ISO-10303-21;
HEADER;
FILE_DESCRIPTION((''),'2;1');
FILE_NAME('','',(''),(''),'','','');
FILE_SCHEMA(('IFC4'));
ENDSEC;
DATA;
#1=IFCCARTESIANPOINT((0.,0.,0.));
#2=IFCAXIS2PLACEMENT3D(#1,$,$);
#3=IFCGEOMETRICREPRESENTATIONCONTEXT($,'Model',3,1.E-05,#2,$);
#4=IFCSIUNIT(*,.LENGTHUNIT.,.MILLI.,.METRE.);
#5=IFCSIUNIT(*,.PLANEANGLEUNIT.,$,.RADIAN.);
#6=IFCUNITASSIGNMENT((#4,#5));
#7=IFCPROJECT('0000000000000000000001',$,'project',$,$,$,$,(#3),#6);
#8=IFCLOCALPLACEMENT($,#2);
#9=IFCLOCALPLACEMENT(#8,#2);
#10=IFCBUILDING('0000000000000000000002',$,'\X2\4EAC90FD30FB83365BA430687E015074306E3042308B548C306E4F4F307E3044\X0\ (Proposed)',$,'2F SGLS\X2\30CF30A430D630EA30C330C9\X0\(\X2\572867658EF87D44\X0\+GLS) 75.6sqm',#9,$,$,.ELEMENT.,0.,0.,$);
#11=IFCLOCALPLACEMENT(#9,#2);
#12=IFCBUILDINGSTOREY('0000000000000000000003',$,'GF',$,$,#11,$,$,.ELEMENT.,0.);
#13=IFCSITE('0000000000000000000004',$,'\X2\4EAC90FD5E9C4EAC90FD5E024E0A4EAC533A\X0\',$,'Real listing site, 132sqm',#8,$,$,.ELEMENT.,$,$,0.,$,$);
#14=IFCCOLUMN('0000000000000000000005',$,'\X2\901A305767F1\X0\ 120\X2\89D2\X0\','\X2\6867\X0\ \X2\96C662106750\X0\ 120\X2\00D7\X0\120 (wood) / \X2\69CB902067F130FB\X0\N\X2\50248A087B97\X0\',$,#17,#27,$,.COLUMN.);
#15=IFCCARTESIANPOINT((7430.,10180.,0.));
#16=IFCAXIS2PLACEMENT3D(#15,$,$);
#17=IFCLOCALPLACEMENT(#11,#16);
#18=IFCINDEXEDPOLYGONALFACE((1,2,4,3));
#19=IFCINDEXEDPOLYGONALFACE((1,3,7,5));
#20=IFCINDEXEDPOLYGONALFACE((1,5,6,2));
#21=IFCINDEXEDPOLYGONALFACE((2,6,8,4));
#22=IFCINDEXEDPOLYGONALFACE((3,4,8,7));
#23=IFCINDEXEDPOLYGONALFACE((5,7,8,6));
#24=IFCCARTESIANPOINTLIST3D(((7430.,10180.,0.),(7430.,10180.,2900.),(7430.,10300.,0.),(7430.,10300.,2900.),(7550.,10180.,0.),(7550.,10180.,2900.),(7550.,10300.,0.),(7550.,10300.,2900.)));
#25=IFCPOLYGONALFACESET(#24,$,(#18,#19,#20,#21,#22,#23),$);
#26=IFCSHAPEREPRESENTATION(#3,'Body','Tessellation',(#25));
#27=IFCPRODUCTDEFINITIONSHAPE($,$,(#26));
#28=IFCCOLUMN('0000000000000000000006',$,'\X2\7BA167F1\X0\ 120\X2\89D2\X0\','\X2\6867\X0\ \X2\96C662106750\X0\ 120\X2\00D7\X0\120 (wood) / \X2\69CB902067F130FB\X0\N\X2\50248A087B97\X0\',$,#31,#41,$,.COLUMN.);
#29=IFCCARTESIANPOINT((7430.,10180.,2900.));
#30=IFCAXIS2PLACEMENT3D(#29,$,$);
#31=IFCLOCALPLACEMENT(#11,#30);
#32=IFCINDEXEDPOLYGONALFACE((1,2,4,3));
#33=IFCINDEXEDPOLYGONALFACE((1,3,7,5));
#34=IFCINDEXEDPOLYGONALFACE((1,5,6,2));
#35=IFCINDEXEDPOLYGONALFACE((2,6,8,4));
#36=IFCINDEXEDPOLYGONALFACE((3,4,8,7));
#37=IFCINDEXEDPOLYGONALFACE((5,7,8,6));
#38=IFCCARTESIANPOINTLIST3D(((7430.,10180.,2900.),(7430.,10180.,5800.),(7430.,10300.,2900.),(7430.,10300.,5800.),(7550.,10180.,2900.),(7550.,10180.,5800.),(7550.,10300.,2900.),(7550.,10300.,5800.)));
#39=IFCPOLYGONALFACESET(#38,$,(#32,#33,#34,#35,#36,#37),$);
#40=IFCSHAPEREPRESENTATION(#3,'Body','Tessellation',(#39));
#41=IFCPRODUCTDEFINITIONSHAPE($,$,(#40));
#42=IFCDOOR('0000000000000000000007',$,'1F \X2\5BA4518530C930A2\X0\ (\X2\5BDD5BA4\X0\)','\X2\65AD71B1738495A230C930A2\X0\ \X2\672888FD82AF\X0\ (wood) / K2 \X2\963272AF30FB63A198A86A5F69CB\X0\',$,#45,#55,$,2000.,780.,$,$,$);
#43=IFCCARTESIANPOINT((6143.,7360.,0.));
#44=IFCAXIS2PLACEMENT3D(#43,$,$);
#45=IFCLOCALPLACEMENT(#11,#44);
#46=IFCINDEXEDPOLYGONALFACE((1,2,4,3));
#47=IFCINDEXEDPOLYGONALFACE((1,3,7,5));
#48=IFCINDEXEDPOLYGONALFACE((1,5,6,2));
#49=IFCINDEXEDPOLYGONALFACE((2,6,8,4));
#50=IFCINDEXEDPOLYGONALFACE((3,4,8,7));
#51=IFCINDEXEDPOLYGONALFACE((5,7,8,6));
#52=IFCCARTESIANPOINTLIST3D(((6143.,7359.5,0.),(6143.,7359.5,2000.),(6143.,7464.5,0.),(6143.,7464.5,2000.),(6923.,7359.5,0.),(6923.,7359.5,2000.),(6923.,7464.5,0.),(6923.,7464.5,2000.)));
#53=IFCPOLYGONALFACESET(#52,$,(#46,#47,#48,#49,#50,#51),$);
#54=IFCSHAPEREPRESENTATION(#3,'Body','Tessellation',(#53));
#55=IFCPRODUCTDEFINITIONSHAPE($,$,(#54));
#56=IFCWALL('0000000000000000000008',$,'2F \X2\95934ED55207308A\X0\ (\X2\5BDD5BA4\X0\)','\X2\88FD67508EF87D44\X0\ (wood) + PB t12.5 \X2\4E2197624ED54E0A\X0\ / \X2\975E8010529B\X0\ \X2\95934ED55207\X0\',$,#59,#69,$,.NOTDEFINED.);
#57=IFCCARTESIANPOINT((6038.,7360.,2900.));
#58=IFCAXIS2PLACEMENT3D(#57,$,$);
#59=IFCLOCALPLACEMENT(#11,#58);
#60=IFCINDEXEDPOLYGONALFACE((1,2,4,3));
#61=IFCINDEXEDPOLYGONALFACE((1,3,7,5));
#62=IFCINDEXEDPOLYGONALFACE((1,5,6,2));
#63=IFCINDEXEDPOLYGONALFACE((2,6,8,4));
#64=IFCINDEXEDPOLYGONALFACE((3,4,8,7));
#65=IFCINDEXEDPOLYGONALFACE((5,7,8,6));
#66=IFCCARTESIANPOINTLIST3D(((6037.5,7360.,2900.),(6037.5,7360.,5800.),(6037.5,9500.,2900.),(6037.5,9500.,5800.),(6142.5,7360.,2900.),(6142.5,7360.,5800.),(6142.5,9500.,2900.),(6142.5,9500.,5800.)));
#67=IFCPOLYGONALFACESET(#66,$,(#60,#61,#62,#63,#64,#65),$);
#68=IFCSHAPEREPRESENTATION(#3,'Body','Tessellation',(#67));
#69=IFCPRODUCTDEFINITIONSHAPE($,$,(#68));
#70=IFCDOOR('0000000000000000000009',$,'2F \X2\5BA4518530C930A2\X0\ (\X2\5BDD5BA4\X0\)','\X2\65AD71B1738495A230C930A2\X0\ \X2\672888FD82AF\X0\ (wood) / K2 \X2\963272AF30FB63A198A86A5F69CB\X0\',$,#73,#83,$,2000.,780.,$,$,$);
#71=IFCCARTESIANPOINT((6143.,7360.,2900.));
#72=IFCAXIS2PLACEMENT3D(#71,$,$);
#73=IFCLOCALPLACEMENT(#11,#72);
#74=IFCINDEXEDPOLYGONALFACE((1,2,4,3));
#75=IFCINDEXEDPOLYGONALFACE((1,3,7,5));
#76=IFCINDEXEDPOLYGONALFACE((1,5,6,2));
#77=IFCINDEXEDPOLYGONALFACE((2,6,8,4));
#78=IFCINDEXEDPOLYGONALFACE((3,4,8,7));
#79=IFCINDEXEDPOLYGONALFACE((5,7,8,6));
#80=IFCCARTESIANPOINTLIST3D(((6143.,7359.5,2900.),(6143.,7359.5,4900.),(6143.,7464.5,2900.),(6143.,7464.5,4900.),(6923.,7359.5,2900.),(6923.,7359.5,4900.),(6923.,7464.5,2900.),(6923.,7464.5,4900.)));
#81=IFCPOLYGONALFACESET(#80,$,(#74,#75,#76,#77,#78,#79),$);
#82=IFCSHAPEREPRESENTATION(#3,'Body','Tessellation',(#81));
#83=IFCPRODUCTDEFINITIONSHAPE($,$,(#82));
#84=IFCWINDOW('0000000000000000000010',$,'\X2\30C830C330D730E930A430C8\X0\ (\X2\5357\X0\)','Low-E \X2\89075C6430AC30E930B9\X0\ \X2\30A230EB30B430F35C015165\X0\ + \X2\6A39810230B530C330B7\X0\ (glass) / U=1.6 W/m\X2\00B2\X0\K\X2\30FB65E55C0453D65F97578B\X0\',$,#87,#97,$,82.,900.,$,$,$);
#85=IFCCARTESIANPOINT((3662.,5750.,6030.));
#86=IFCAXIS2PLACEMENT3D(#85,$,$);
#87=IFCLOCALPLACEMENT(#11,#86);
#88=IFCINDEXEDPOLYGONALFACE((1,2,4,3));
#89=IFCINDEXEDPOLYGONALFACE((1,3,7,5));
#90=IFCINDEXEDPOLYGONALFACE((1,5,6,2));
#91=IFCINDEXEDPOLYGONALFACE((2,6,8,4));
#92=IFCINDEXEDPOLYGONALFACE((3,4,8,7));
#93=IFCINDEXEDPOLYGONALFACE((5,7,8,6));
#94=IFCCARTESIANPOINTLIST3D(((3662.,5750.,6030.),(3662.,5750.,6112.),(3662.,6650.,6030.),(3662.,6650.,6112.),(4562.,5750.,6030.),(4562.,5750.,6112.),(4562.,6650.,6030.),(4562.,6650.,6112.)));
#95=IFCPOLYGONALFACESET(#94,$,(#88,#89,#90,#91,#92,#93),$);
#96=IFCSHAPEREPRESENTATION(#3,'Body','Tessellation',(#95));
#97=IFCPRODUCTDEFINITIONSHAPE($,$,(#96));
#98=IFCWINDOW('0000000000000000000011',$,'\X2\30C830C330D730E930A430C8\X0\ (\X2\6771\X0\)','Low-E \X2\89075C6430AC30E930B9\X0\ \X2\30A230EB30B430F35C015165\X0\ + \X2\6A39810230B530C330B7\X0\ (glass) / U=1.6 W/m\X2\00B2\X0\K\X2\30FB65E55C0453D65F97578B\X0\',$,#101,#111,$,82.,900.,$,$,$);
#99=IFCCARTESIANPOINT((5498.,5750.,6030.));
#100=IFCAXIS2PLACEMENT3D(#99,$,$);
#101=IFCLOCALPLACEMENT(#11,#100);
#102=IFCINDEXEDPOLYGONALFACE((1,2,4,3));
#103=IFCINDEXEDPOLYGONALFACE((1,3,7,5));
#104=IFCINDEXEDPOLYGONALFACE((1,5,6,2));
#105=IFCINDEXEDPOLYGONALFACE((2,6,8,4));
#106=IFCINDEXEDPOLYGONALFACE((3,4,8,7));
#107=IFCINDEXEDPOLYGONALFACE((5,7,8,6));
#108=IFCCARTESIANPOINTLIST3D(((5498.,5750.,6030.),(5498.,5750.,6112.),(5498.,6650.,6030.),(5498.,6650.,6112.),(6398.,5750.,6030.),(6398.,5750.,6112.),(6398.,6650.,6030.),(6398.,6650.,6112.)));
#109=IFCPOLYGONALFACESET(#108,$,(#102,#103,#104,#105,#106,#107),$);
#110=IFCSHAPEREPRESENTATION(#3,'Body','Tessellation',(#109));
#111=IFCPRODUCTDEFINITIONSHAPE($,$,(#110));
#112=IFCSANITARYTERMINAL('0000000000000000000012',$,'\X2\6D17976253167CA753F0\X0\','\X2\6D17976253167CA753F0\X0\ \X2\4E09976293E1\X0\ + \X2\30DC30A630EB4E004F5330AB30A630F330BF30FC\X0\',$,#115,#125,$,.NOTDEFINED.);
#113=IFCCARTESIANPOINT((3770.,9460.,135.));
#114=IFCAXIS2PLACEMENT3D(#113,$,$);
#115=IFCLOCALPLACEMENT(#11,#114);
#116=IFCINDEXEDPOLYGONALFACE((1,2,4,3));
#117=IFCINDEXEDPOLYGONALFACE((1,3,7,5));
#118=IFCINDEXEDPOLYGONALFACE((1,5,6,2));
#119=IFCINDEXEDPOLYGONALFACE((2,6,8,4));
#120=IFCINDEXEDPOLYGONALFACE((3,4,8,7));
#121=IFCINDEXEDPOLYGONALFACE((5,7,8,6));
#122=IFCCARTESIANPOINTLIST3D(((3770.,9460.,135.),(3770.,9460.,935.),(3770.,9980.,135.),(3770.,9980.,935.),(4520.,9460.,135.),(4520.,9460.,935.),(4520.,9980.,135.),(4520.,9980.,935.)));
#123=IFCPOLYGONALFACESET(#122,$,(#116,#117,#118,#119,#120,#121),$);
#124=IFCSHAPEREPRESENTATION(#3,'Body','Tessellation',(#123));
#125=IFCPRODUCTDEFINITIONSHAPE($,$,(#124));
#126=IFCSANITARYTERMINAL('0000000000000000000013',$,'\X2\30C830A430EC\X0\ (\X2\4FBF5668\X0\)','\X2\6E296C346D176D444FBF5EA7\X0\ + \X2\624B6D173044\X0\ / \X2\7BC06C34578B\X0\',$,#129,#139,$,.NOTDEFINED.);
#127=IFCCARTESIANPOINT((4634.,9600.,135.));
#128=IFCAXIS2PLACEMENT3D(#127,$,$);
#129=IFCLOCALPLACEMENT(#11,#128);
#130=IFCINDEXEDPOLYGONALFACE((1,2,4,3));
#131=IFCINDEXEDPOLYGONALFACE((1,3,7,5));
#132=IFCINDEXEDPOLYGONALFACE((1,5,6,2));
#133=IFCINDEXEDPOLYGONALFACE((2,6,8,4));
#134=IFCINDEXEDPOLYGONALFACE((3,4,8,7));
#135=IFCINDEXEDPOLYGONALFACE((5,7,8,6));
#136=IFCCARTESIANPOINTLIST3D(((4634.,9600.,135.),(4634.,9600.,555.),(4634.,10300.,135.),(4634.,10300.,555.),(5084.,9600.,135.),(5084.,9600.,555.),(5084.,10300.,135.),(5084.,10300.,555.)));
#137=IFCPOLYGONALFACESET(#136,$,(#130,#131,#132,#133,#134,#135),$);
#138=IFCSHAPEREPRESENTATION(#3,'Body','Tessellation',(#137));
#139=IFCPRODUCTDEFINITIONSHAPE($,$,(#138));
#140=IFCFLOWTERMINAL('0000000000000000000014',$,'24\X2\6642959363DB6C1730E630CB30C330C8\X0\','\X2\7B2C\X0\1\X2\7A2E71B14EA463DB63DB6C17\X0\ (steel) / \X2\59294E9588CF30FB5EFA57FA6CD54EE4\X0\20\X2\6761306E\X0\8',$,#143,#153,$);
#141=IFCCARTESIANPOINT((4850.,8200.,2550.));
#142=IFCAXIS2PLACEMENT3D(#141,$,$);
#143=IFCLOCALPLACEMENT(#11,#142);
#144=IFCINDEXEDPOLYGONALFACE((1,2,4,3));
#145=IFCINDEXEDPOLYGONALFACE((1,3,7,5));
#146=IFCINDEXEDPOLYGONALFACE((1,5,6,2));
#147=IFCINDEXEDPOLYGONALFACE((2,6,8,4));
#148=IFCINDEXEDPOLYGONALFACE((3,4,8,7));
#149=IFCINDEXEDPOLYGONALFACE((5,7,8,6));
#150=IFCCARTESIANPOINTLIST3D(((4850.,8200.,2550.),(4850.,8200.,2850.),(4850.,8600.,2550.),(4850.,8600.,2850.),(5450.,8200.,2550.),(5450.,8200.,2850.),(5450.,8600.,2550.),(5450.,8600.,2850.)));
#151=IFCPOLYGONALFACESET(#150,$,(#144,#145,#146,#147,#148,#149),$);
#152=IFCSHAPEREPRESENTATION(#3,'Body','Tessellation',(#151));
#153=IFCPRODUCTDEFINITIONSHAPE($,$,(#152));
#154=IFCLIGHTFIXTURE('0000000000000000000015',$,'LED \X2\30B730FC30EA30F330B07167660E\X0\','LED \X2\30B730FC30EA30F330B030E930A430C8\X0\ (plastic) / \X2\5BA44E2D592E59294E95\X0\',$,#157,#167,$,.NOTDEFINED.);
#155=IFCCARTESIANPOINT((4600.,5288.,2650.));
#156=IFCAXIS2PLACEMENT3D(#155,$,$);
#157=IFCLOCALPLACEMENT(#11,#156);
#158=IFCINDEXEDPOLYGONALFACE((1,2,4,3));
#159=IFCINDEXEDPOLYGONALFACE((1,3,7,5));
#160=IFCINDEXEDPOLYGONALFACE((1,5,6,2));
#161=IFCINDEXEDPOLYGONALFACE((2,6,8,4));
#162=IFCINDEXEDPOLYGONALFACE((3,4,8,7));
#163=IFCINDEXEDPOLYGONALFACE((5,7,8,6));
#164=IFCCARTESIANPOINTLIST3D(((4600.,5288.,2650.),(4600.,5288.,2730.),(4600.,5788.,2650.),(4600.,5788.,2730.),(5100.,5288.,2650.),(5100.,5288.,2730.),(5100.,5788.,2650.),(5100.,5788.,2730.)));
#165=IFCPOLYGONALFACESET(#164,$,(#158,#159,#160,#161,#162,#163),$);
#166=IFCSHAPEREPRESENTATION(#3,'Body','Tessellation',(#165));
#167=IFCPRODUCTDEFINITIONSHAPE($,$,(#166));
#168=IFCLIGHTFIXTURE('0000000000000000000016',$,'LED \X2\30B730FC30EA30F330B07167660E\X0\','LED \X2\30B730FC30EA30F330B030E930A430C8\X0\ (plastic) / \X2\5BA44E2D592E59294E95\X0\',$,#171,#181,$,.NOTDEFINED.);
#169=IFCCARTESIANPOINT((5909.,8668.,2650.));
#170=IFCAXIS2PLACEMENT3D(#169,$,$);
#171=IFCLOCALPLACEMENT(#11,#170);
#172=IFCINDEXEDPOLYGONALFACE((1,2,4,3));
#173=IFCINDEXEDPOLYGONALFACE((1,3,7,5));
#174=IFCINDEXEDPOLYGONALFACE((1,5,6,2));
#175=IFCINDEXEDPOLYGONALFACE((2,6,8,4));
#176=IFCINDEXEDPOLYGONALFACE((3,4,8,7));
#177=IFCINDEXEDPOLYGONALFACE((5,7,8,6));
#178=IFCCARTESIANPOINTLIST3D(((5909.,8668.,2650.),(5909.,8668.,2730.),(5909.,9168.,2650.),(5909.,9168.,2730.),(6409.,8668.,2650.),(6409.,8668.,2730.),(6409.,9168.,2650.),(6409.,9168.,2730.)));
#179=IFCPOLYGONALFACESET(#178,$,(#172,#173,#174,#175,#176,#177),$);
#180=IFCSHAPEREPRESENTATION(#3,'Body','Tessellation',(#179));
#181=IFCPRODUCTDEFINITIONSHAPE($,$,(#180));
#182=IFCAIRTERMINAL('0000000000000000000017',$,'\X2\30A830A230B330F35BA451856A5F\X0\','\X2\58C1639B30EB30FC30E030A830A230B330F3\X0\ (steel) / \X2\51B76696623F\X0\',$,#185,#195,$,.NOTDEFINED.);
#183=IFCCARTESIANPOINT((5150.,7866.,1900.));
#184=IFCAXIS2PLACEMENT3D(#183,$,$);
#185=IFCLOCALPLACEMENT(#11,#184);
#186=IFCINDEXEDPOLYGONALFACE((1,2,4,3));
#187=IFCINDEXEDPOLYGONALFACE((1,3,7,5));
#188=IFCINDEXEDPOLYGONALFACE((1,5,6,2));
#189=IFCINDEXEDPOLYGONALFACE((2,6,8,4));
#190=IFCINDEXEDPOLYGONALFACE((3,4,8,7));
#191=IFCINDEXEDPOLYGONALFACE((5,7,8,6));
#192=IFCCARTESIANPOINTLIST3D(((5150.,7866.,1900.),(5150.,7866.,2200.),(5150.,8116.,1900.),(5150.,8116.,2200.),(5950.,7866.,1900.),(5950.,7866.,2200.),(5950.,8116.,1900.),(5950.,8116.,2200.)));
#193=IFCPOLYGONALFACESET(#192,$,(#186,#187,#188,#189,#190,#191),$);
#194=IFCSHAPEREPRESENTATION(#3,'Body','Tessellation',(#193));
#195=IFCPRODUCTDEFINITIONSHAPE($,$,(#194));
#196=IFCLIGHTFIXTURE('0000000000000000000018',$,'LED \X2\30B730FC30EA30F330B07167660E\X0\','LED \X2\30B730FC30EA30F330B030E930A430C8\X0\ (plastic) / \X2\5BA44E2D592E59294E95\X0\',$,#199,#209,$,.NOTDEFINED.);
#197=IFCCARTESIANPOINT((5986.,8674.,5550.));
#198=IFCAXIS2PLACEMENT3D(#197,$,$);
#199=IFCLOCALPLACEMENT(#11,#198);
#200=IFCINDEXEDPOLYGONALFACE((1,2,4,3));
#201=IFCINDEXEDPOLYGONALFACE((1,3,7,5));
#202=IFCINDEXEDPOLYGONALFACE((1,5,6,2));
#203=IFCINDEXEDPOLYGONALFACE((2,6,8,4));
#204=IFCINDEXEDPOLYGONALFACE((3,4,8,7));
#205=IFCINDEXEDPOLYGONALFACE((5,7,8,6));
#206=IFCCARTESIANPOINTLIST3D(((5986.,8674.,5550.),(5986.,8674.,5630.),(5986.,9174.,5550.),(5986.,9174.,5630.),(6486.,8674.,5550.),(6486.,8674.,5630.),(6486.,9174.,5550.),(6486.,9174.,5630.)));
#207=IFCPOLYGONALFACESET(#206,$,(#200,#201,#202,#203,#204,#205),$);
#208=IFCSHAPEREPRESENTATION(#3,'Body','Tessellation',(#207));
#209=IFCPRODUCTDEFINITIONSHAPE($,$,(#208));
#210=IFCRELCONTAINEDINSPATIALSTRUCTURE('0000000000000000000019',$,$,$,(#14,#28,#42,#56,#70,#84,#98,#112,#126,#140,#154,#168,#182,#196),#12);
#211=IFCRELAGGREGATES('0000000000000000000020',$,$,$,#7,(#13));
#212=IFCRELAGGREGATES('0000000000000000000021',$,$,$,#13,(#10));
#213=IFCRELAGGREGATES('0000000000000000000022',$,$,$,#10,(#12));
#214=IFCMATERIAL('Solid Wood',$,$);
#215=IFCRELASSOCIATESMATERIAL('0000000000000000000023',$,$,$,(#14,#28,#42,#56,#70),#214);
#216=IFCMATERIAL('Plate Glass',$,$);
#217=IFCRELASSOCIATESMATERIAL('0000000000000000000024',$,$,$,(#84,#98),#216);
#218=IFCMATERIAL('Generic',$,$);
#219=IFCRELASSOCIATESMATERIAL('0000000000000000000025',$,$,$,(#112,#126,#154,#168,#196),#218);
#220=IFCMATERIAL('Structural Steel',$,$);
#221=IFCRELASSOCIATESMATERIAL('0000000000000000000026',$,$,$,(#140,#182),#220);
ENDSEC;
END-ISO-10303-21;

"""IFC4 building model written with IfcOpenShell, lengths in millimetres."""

from ifc_helpers import new_model, si_unit, frame, frame_2d, origin, place, context, project, spatial, rectangle, extrude, material, element, save


model = new_model("IFC4")

# Units and contexts
model_context = context("Model", 3, precision=1e-05, world=origin())
ifc_project = project(units=[si_unit("LENGTHUNIT", "METRE", prefix="MILLI"), si_unit("PLANEANGLEUNIT", "RADIAN")], contexts=[model_context])

# Site, building, storey
site_placement = place(None, origin())
site = spatial("IfcSite", under=ifc_project, at=site_placement, Name="京都府京都市上京区", ObjectType="Real listing site, 132sqm", CompositionType="ELEMENT", RefElevation=0.0)
building_placement = place(site_placement, origin())
building = spatial("IfcBuilding", under=site, at=building_placement, Name="京都・茶室と縁側のある和の住まい (Proposed)", ObjectType="2F SGLSハイブリッド(在来軸組+GLS) 75.6sqm", CompositionType="ELEMENT", ElevationOfRefHeight=0.0, ElevationOfTerrain=0.0)
storey_placement = place(building_placement, origin())
storey = spatial("IfcBuildingStorey", under=building, at=storey_placement, Name="GF", CompositionType="ELEMENT", Elevation=0.0)

# Columns
ifc_material_1 = material(Name="Solid Wood")
column_1_placement = place(storey_placement, frame((7430.0, 10180.0, 0.0)))
element("IfcColumn", 1, at=column_1_placement, inside=storey, material=ifc_material_1, Name="通し柱 120角", Description="桧 集成材 120×120 (wood) / 構造柱・N値計算", PredefinedType="COLUMN", context=model_context, shape_type="SweptSolid", body=[
    extrude(rectangle(XDim=120.0, YDim=120.0, at=frame_2d((60.0, 60.0))), frame((7430.0, 10180.0, 0.0)), (0.0, 0.0, 1.0), 2900.0),
])
column_2_placement = place(storey_placement, frame((7430.0, 10180.0, 2900.0)))
element("IfcColumn", 2, at=column_2_placement, inside=storey, material=ifc_material_1, Name="管柱 120角", Description="桧 集成材 120×120 (wood) / 構造柱・N値計算", PredefinedType="COLUMN", context=model_context, shape_type="SweptSolid", body=[
    extrude(rectangle(XDim=120.0, YDim=120.0, at=frame_2d((60.0, 60.0))), frame((7430.0, 10180.0, 2900.0)), (0.0, 0.0, 1.0), 2900.0),
])

# Door
door_1_placement = place(storey_placement, frame((6143.0, 7360.0, 0.0)))
element("IfcDoor", 3, at=door_1_placement, inside=storey, material=ifc_material_1, Name="1F 室内ドア (寝室)", Description="断熱玄関ドア 木製芯 (wood) / K2 防犯・採風機構", OverallHeight=2000.0, OverallWidth=780.0, context=model_context, shape_type="SweptSolid", body=[
    extrude(rectangle(XDim=780.0, YDim=105.0, at=frame_2d((390.0, 52.0))), frame((6143.0, 7360.0, 0.0)), (0.0, 0.0, 1.0), 2000.0),
])

# Wall
wall_1_placement = place(storey_placement, frame((6038.0, 7360.0, 2900.0)))
element("IfcWall", 4, at=wall_1_placement, inside=storey, material=ifc_material_1, Name="2F 間仕切り (寝室)", Description="製材軸組 (wood) + PB t12.5 両面仕上 / 非耐力 間仕切", PredefinedType="NOTDEFINED", context=model_context, shape_type="SweptSolid", body=[
    extrude(rectangle(XDim=105.0, YDim=2140.0, at=frame_2d((52.0, 1070.0))), frame((6038.0, 7360.0, 2900.0)), (0.0, 0.0, 1.0), 2900.0),
])

# Door
door_2_placement = place(storey_placement, frame((6143.0, 7360.0, 2900.0)))
element("IfcDoor", 5, at=door_2_placement, inside=storey, material=ifc_material_1, Name="2F 室内ドア (寝室)", Description="断熱玄関ドア 木製芯 (wood) / K2 防犯・採風機構", OverallHeight=2000.0, OverallWidth=780.0, context=model_context, shape_type="SweptSolid", body=[
    extrude(rectangle(XDim=780.0, YDim=105.0, at=frame_2d((390.0, 52.0))), frame((6143.0, 7360.0, 2900.0)), (0.0, 0.0, 1.0), 2000.0),
])

# Windows
ifc_material_2 = material(Name="Plate Glass")
window_1_placement = place(storey_placement, frame((3662.0, 5750.0, 6030.0)))
element("IfcWindow", 6, at=window_1_placement, inside=storey, material=ifc_material_2, Name="トップライト (南)", Description="Low-E 複層ガラス アルゴン封入 + 樹脂サッシ (glass) / U=1.6 W/m²K・日射取得型", OverallHeight=82.0, OverallWidth=900.0, context=model_context, shape_type="SweptSolid", body=[
    extrude(rectangle(XDim=900.0, YDim=900.0, at=frame_2d((450.0, 450.0))), frame((3662.0, 5750.0, 6030.0)), (0.0, 0.0, 1.0), 82.0),
])
window_2_placement = place(storey_placement, frame((5498.0, 5750.0, 6030.0)))
element("IfcWindow", 7, at=window_2_placement, inside=storey, material=ifc_material_2, Name="トップライト (東)", Description="Low-E 複層ガラス アルゴン封入 + 樹脂サッシ (glass) / U=1.6 W/m²K・日射取得型", OverallHeight=82.0, OverallWidth=900.0, context=model_context, shape_type="SweptSolid", body=[
    extrude(rectangle(XDim=900.0, YDim=900.0, at=frame_2d((450.0, 450.0))), frame((5498.0, 5750.0, 6030.0)), (0.0, 0.0, 1.0), 82.0),
])

# Sanitary terminals
ifc_material_3 = material(Name="Generic")
sanitary_terminal_1_placement = place(storey_placement, frame((3770.0, 9460.0, 135.0)))
element("IfcSanitaryTerminal", 8, at=sanitary_terminal_1_placement, inside=storey, material=ifc_material_3, Name="洗面化粧台", Description="洗面化粧台 三面鏡 + ボウル一体カウンター", PredefinedType="NOTDEFINED", context=model_context, shape_type="SweptSolid", body=[
    extrude(rectangle(XDim=750.0, YDim=520.0, at=frame_2d((375.0, 260.0))), frame((3770.0, 9460.0, 135.0)), (0.0, 0.0, 1.0), 800.0),
])
sanitary_terminal_2_placement = place(storey_placement, frame((4634.0, 9600.0, 135.0)))
element("IfcSanitaryTerminal", 9, at=sanitary_terminal_2_placement, inside=storey, material=ifc_material_3, Name="トイレ (便器)", Description="温水洗浄便座 + 手洗い / 節水型", PredefinedType="NOTDEFINED", context=model_context, shape_type="SweptSolid", body=[
    extrude(rectangle(XDim=450.0, YDim=700.0, at=frame_2d((225.0, 350.0))), frame((4634.0, 9600.0, 135.0)), (0.0, 0.0, 1.0), 420.0),
])

# Flow terminal
ifc_material_4 = material(Name="Structural Steel")
flow_terminal_placement = place(storey_placement, frame((4850.0, 8200.0, 2550.0)))
element("IfcFlowTerminal", 10, at=flow_terminal_placement, inside=storey, material=ifc_material_4, Name="24時間換気ユニット", Description="第1種熱交換換気 (steel) / 天井裏・建基法令20条の8", context=model_context, shape_type="SweptSolid", body=[
    extrude(rectangle(XDim=600.0, YDim=400.0, at=frame_2d((300.0, 200.0))), frame((4850.0, 8200.0, 2550.0)), (0.0, 0.0, 1.0), 300.0),
])

# Light fixtures
light_fixture_1_placement = place(storey_placement, frame((4600.0, 5288.0, 2650.0)))
element("IfcLightFixture", 11, at=light_fixture_1_placement, inside=storey, material=ifc_material_3, Name="LED シーリング照明", Description="LED シーリングライト (plastic) / 室中央天井", PredefinedType="NOTDEFINED", context=model_context, shape_type="SweptSolid", body=[
    extrude(rectangle(XDim=500.0, YDim=500.0, at=frame_2d((250.0, 250.0))), frame((4600.0, 5288.0, 2650.0)), (0.0, 0.0, 1.0), 80.0),
])
light_fixture_2_placement = place(storey_placement, frame((5909.0, 8668.0, 2650.0)))
element("IfcLightFixture", 12, at=light_fixture_2_placement, inside=storey, material=ifc_material_3, Name="LED シーリング照明", Description="LED シーリングライト (plastic) / 室中央天井", PredefinedType="NOTDEFINED", context=model_context, shape_type="SweptSolid", body=[
    extrude(rectangle(XDim=500.0, YDim=500.0, at=frame_2d((250.0, 250.0))), frame((5909.0, 8668.0, 2650.0)), (0.0, 0.0, 1.0), 80.0),
])

# Air terminal
air_terminal_placement = place(storey_placement, frame((5150.0, 7866.0, 1900.0)))
element("IfcAirTerminal", 13, at=air_terminal_placement, inside=storey, material=ifc_material_4, Name="エアコン室内機", Description="壁掛ルームエアコン (steel) / 冷暖房", PredefinedType="NOTDEFINED", context=model_context, shape_type="SweptSolid", body=[
    extrude(rectangle(XDim=800.0, YDim=250.0, at=frame_2d((400.0, 125.0))), frame((5150.0, 7866.0, 1900.0)), (0.0, 0.0, 1.0), 300.0),
])

# Light fixture
light_fixture_3_placement = place(storey_placement, frame((5986.0, 8674.0, 5550.0)))
element("IfcLightFixture", 14, at=light_fixture_3_placement, inside=storey, material=ifc_material_3, Name="LED シーリング照明", Description="LED シーリングライト (plastic) / 室中央天井", PredefinedType="NOTDEFINED", context=model_context, shape_type="SweptSolid", body=[
    extrude(rectangle(XDim=500.0, YDim=500.0, at=frame_2d((250.0, 250.0))), frame((5986.0, 8674.0, 5550.0)), (0.0, 0.0, 1.0), 80.0),
])

save(model, "model.ifc")
